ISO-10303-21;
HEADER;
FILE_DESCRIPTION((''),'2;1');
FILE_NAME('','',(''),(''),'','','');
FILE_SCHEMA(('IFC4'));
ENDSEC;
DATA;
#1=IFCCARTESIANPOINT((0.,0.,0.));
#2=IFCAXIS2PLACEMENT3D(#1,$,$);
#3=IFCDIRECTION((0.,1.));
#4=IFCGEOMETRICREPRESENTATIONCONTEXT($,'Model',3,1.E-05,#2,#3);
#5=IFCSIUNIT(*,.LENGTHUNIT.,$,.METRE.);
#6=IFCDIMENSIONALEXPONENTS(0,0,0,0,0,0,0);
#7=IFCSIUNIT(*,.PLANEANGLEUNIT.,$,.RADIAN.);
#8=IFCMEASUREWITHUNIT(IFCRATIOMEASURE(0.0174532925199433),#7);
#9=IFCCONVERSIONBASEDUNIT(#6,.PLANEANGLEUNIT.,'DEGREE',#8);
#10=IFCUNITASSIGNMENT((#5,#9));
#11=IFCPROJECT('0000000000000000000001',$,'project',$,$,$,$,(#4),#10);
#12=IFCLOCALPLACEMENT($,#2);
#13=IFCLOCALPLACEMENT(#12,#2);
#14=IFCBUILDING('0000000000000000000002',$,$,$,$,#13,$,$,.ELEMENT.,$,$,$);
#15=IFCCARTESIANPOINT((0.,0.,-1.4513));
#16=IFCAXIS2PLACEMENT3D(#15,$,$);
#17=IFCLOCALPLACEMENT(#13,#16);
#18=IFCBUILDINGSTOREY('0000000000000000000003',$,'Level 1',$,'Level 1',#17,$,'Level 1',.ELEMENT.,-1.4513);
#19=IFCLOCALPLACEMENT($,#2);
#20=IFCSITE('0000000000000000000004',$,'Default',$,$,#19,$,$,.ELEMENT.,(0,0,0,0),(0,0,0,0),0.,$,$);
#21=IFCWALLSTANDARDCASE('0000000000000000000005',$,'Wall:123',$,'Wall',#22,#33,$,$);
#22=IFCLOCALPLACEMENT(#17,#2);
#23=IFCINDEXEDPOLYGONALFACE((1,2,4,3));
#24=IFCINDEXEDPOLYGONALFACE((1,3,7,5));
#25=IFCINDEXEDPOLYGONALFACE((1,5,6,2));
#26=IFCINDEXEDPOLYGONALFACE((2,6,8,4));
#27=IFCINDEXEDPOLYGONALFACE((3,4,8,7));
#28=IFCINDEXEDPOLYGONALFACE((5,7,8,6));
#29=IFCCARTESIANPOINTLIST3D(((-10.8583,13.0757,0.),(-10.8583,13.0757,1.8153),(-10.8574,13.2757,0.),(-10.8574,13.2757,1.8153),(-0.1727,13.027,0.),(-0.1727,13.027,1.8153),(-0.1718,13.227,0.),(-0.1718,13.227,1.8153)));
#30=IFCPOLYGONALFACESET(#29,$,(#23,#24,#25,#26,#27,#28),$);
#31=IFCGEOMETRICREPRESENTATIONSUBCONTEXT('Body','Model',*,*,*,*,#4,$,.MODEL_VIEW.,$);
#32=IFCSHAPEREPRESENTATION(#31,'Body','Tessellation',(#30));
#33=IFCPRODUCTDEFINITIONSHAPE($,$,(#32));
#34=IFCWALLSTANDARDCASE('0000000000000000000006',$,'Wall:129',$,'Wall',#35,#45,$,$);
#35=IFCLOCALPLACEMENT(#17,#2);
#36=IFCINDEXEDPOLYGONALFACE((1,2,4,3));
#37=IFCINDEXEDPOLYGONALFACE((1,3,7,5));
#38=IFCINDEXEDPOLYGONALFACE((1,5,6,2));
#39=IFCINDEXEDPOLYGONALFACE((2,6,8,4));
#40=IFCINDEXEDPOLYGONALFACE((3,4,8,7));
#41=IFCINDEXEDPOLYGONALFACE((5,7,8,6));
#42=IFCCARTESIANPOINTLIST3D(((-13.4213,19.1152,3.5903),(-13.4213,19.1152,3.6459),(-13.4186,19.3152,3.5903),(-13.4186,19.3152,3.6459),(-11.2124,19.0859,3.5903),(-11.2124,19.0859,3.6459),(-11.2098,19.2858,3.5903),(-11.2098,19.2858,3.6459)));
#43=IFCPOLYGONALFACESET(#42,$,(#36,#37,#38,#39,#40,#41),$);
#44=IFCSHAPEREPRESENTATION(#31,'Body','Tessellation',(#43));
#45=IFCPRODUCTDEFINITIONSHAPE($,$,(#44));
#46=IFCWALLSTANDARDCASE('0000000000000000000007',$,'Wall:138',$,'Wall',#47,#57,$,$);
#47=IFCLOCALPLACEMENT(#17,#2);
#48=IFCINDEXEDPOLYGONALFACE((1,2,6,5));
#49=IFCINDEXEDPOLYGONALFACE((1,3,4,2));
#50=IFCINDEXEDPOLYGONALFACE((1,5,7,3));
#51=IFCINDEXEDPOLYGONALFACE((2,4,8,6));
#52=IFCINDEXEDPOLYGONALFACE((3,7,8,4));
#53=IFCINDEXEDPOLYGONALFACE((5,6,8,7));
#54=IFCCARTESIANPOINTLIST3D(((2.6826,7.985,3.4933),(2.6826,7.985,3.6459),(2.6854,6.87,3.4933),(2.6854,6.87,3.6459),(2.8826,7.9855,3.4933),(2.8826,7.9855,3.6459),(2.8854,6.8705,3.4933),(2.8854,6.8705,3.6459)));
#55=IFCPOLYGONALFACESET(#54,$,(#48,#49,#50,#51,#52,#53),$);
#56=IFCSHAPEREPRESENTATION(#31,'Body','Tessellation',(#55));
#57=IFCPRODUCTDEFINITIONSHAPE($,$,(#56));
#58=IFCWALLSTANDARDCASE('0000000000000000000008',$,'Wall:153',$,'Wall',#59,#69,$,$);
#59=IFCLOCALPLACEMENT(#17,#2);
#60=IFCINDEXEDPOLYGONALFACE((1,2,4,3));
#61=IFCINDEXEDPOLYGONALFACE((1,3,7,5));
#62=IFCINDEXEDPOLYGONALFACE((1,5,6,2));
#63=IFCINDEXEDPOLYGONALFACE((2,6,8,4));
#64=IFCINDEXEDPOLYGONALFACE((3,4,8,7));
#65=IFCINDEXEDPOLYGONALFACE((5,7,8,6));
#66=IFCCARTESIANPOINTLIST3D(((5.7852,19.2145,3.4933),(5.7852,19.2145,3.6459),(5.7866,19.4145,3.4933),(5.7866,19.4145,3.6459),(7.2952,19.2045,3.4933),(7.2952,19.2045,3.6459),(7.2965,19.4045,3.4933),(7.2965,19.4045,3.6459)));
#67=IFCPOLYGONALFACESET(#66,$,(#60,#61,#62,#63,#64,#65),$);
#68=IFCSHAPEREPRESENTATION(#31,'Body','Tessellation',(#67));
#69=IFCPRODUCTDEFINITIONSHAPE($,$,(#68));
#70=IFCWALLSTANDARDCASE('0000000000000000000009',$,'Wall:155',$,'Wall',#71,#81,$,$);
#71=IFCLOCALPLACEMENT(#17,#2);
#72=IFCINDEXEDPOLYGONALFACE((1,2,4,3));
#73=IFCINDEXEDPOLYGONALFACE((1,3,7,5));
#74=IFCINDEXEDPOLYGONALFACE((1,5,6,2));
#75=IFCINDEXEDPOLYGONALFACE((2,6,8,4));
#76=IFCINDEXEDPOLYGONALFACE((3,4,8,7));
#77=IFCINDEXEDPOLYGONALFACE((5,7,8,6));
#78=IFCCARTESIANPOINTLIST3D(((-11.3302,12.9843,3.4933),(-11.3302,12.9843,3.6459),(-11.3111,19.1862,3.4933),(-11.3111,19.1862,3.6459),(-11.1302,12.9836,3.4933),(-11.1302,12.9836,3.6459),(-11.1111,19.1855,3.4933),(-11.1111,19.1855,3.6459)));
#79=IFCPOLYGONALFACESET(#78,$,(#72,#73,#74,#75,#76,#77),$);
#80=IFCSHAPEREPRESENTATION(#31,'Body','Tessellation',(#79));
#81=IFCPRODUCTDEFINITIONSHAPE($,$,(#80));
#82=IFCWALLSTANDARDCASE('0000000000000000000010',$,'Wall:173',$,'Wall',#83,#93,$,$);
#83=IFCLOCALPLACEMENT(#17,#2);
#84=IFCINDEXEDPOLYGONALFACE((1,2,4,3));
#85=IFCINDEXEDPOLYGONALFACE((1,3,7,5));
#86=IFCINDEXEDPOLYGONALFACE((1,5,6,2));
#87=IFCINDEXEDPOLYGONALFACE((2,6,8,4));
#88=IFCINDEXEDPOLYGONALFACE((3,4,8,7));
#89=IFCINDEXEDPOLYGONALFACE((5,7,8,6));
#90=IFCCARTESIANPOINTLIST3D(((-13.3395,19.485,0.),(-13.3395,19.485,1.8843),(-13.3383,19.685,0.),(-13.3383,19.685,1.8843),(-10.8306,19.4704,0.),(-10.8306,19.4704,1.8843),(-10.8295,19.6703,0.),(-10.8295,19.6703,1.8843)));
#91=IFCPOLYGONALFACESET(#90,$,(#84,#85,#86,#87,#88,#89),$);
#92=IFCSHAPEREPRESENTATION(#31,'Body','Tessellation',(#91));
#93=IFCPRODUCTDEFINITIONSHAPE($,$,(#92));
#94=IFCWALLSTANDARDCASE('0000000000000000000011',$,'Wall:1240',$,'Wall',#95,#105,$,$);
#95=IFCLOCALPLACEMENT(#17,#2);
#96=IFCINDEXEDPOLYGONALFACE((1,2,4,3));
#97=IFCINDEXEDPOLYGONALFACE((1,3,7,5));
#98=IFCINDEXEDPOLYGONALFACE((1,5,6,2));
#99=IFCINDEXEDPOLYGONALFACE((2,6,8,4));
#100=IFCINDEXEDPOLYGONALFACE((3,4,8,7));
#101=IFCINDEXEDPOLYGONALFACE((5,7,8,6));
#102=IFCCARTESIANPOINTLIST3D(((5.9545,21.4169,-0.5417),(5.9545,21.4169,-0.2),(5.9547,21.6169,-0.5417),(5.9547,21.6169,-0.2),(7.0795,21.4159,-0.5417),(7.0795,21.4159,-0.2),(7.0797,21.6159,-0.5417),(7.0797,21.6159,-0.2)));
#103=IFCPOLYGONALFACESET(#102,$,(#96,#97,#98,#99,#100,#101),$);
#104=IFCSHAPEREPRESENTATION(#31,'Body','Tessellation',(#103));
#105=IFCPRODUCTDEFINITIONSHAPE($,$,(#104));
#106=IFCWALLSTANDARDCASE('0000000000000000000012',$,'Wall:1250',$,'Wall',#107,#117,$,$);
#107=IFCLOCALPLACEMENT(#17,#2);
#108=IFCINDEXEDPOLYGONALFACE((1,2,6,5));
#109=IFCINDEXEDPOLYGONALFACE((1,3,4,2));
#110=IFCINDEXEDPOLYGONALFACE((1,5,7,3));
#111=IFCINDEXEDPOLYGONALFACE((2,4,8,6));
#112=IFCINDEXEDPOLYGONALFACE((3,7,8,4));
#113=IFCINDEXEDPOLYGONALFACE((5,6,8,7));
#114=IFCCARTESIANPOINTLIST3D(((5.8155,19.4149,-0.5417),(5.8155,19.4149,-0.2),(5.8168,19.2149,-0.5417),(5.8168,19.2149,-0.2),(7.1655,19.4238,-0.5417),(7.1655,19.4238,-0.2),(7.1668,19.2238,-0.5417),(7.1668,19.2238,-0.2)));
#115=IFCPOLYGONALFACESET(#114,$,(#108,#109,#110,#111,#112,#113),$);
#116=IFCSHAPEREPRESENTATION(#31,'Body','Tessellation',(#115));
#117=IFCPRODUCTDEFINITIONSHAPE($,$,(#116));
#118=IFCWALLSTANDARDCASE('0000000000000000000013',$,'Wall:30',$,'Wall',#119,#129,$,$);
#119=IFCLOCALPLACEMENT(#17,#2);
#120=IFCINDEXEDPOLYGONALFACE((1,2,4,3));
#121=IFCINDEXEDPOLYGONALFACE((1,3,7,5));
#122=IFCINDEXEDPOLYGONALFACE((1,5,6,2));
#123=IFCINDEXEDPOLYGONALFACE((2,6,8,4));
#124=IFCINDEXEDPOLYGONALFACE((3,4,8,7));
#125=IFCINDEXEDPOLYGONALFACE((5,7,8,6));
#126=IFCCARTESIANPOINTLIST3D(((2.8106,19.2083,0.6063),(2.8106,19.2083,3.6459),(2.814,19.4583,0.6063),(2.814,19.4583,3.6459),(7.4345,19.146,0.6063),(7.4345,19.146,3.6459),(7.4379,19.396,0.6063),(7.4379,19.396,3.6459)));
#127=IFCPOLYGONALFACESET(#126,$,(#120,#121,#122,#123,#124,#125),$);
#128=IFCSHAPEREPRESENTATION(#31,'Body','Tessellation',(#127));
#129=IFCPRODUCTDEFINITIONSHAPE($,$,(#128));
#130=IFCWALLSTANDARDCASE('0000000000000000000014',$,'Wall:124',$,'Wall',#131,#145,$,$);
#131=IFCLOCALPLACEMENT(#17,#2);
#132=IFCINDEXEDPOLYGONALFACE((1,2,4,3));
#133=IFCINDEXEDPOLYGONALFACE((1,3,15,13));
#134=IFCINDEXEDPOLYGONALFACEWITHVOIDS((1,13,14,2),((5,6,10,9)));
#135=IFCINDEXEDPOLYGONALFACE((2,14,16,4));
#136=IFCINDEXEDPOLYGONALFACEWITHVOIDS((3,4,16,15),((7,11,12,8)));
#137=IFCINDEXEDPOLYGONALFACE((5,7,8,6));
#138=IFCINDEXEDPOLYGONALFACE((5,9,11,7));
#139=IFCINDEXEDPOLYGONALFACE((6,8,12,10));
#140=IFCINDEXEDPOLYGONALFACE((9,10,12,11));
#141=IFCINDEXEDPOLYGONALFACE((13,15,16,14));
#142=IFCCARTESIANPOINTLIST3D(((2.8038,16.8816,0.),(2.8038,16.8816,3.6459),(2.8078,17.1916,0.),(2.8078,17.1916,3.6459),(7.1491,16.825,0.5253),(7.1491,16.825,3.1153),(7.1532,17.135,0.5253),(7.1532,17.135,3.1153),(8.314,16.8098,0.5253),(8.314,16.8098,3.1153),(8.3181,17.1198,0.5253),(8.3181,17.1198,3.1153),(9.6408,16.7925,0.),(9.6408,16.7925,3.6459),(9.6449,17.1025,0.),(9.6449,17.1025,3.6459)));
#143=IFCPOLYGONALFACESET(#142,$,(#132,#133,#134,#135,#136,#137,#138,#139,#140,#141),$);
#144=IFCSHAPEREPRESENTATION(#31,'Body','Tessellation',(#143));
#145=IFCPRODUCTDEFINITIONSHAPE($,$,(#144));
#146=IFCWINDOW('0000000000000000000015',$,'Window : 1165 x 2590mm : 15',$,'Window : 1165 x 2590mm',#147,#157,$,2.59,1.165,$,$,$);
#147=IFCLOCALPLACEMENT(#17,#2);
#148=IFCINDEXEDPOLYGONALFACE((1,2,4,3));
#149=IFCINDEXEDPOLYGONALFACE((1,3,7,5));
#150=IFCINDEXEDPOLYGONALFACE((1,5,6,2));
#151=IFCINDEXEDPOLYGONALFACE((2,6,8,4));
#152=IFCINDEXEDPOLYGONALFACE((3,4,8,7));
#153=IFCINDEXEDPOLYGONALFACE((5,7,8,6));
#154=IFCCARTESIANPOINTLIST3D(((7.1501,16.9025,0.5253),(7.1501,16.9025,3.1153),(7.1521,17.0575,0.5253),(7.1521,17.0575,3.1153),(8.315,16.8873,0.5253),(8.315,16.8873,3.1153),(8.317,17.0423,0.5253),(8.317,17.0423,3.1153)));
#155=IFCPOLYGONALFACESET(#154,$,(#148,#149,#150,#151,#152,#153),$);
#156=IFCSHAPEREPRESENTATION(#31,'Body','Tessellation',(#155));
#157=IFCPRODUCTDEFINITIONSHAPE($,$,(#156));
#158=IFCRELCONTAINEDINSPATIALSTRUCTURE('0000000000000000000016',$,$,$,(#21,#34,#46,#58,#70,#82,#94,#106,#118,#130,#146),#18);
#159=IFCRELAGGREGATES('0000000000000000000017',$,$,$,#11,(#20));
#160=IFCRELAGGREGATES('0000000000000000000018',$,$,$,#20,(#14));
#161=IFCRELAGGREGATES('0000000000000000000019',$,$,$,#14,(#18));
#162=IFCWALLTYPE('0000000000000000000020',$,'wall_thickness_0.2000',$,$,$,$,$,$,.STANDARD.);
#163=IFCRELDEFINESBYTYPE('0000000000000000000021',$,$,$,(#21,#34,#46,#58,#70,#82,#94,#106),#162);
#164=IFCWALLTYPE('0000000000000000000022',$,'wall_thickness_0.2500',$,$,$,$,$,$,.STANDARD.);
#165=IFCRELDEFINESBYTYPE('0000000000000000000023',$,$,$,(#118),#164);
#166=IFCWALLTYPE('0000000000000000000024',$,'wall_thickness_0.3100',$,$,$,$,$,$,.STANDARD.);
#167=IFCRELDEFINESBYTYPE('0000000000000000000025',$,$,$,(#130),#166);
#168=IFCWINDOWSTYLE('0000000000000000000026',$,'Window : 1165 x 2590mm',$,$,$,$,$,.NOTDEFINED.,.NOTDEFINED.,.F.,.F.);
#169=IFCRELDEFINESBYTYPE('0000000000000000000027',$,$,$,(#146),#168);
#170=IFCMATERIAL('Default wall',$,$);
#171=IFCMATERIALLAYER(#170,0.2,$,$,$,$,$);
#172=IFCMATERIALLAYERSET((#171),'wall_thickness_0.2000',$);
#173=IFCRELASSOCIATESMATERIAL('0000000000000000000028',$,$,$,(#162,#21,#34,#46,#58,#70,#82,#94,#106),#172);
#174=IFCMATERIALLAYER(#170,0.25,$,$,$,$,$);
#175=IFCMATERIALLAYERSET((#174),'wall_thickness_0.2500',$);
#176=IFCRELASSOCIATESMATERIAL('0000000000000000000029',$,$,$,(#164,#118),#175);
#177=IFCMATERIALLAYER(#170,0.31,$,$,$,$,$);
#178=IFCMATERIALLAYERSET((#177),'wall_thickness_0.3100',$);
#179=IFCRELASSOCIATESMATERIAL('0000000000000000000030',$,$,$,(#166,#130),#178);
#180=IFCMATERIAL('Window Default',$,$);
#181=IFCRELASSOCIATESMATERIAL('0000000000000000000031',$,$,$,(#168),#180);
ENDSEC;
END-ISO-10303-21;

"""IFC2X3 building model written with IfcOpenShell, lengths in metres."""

from ifc_helpers import new_model, entity, si_unit, converted_unit, direction, frame, frame_2d, origin, origin_2d_with_axis, place, context, subcontext, project, spatial, polyline, rectangle, outline, extrude, source, transform, mapped, material, layer, layer_set, layer_usage, type_object, type_shapes, element, fill, save


model = new_model("IFC2X3")

# Units and contexts
model_context = context("Model", 3, precision=1e-05, world=origin(), true_north=direction((0.0, 1.0)))
body_context = subcontext(model_context, "Body", "Model", "MODEL_VIEW")
ifc_project = project(units=[si_unit("LENGTHUNIT", "METRE"), converted_unit("PLANEANGLEUNIT", "DEGREE", entity("IfcRatioMeasure", 0.0174532925199433), si_unit("PLANEANGLEUNIT", "RADIAN"), dimensions=[0, 0, 0, 0, 0, 0, 0])], contexts=[model_context])

# Site, building, storey
site_placement = place(None, origin())
site = spatial("IfcSite", under=ifc_project, at=site_placement, Name="Default", CompositionType="ELEMENT", RefLatitude=(0, 0, 0, 0), RefLongitude=(0, 0, 0, 0), RefElevation=0.0)
placement_1 = place(None, origin())
building_placement = place(placement_1, origin())
building = spatial("IfcBuilding", under=site, at=building_placement, CompositionType="ELEMENT")
storey_placement = place(building_placement, frame((0.0, 0.0, -1.4513)))
storey = spatial("IfcBuildingStorey", under=building, at=storey_placement, Name="Level 1", ObjectType="Level 1", LongName="Level 1", CompositionType="ELEMENT", Elevation=-1.4513)

# Shared definitions
ifc_material_1 = material(Name="Default wall")

# Shared definitions
ifc_material_2 = material(Name="Window Default")

# Walls
ifc_layer_1 = layer(ifc_material_1, 0.2)
ifc_layer_set_1 = layer_set([ifc_layer_1], Name="wall_thickness_0.2000")
ifc_layer_usage_1 = layer_usage(ifc_layer_set_1, "AXIS2", "POSITIVE", -0.1)
wall_type_1 = type_object("IfcWallType", Name="wall_thickness_0.2000", PredefinedType="STANDARD", material=ifc_layer_set_1)
wall_1_placement = place(storey_placement, frame((-10.8578, 13.1757, 0.0), z_axis=(0.0, 0.0, 1.0), x_axis=(0.99999, -0.004551, 0.0)))
element("IfcWallStandardCase", 1, at=wall_1_placement, inside=storey, type_object=wall_type_1, material=ifc_layer_usage_1, Name="Wall:123", ObjectType="Wall", context=body_context, shape_type="SweptSolid", body=[
    extrude(outline(polyline([(10.6857, -0.1), (10.6857, 0.1), (0.0, 0.1), (0.0, -0.1), (10.6857, -0.1)])), origin(), (0.0, 0.0, 1.0), 1.8153),
])
placement_2 = place(building_placement, frame((0.0, 0.0, 2.139)))
wall_2_placement = place(placement_2, frame((-13.4199, 19.2152, 0.0), z_axis=(0.0, 0.0, 1.0), x_axis=(0.999912, -0.013278, 0.0)))
element("IfcWallStandardCase", 2, at=wall_2_placement, inside=storey, type_object=wall_type_1, material=ifc_layer_usage_1, Name="Wall:129", ObjectType="Wall", context=body_context, shape_type="SweptSolid", body=[
    extrude(outline(polyline([(2.209, -0.1), (2.209, 0.1), (0.0, 0.1), (0.0, -0.1), (2.209, -0.1)])), origin(), (0.0, 0.0, 1.0), 0.0556),
])
placement_3 = place(building_placement, frame((0.0, 0.0, 2.042)))
wall_3_placement = place(placement_3, frame((2.7826, 7.9852, 0.0), z_axis=(0.0, 0.0, 1.0), x_axis=(0.002486, -0.999997, 0.0)))
element("IfcWallStandardCase", 3, at=wall_3_placement, inside=storey, type_object=wall_type_1, material=ifc_layer_usage_1, Name="Wall:138", ObjectType="Wall", context=body_context, shape_type="SweptSolid", body=[
    extrude(outline(polyline([(1.115, -0.1), (1.115, 0.1), (0.0, 0.1), (0.0, -0.1), (1.115, -0.1)])), origin(), (0.0, 0.0, 1.0), 0.1526),
])
placement_4 = place(building_placement, frame((0.0, 0.0, 2.042)))
wall_4_placement = place(placement_4, frame((5.7859, 19.3145, 0.0), z_axis=(0.0, 0.0, 1.0), x_axis=(0.999978, -0.006621, 0.0)))
element("IfcWallStandardCase", 4, at=wall_4_placement, inside=storey, type_object=wall_type_1, material=ifc_layer_usage_1, Name="Wall:153", ObjectType="Wall", context=body_context, shape_type="SweptSolid", body=[
    extrude(outline(polyline([(1.51, -0.1), (1.51, 0.1), (0.0, 0.1), (0.0, -0.1), (1.51, -0.1)])), origin(), (0.0, 0.0, 1.0), 0.1526),
])
placement_5 = place(building_placement, frame((0.0, 0.0, 2.042)))
wall_5_placement = place(placement_5, frame((-11.2111, 19.1859, 0.0), z_axis=(0.0, 0.0, 1.0), x_axis=(-0.003082, -0.999995, 0.0)))
element("IfcWallStandardCase", 5, at=wall_5_placement, inside=storey, type_object=wall_type_1, material=ifc_layer_usage_1, Name="Wall:155", ObjectType="Wall", context=body_context, shape_type="SweptSolid", body=[
    extrude(outline(polyline([(6.2019, -0.1), (6.2019, 0.1), (0.0, 0.1), (0.0, -0.1), (6.2019, -0.1)])), origin(), (0.0, 0.0, 1.0), 0.1526),
])
wall_6_placement = place(storey_placement, frame((-13.3389, 19.585, 0.0), z_axis=(0.0, 0.0, 1.0), x_axis=(0.999983, -0.005854, 0.0)))
element("IfcWallStandardCase", 6, at=wall_6_placement, inside=storey, type_object=wall_type_1, material=ifc_layer_usage_1, Name="Wall:173", ObjectType="Wall", context=body_context, shape_type="SweptSolid", body=[
    extrude(outline(polyline([(2.5089, -0.1), (2.5089, 0.1), (0.0, 0.1), (0.0, -0.1), (2.5089, -0.1)])), origin(), (0.0, 0.0, 1.0), 1.8843),
])
placement_6 = place(building_placement, frame((0.0, 0.0, -1.993)))
wall_7_placement = place(placement_6, frame((5.9546, 21.5169, 0.0), z_axis=(0.0, 0.0, 1.0), x_axis=(1.0, -0.000819, 0.0)))
element("IfcWallStandardCase", 7, at=wall_7_placement, inside=storey, type_object=wall_type_1, material=ifc_layer_usage_1, Name="Wall:1240", ObjectType="Wall", context=body_context, shape_type="SweptSolid", body=[
    extrude(outline(polyline([(1.125, -0.1), (1.125, 0.1), (0.0, 0.1), (0.0, -0.1), (1.125, -0.1)])), origin(), (0.0, 0.0, 1.0), 0.3417),
])
placement_7 = place(building_placement, frame((0.0, 0.0, -1.993)))
wall_8_placement = place(placement_7, frame((5.8161, 19.3149, 0.0), z_axis=(0.0, 0.0, 1.0), x_axis=(0.999978, 0.006563, 0.0)))
element("IfcWallStandardCase", 8, at=wall_8_placement, inside=storey, type_object=wall_type_1, material=ifc_layer_usage_1, Name="Wall:1250", ObjectType="Wall", context=body_context, shape_type="SweptSolid", body=[
    extrude(outline(polyline([(1.35, -0.1), (1.35, 0.1), (0.0, 0.1), (0.0, -0.1), (1.35, -0.1)])), origin(), (0.0, 0.0, 1.0), 0.3417),
])
ifc_layer_2 = layer(ifc_material_1, 0.25)
ifc_layer_set_2 = layer_set([ifc_layer_2], Name="wall_thickness_0.2500")
ifc_layer_usage_2 = layer_usage(ifc_layer_set_2, "AXIS2", "POSITIVE", -0.125)
wall_type_2 = type_object("IfcWallType", Name="wall_thickness_0.2500", PredefinedType="STANDARD", material=ifc_layer_set_2)
placement_8 = place(building_placement, frame((0.0, 0.0, -0.845)))
wall_9_placement = place(placement_8, frame((2.8123, 19.3333, 0.0), z_axis=(0.0, 0.0, 1.0), x_axis=(0.999909, -0.013466, 0.0)))
element("IfcWallStandardCase", 9, at=wall_9_placement, inside=storey, type_object=wall_type_2, material=ifc_layer_usage_2, Name="Wall:30", ObjectType="Wall", context=body_context, shape_type="SweptSolid", body=[
    extrude(outline(polyline([(4.6243, -0.125), (4.6243, 0.125), (0.0, 0.125), (0.0, -0.125), (4.6243, -0.125)])), origin(), (0.0, 0.0, 1.0), 3.0396),
])

# Wall, opening, window
ifc_layer_3 = layer(ifc_material_1, 0.31)
ifc_layer_set_3 = layer_set([ifc_layer_3], Name="wall_thickness_0.3100")
ifc_layer_usage_3 = layer_usage(ifc_layer_set_3, "AXIS2", "POSITIVE", -0.155)
wall_type_3 = type_object("IfcWallType", Name="wall_thickness_0.3100", PredefinedType="STANDARD", material=ifc_layer_set_3)
wall_10_placement = place(storey_placement, frame((2.8058, 17.0366, 0.0), z_axis=(0.0, 0.0, 1.0), x_axis=(0.999915, -0.013032, 0.0)))
wall_10 = element("IfcWallStandardCase", 10, at=wall_10_placement, inside=storey, type_object=wall_type_3, material=ifc_layer_usage_3, Name="Wall:124", ObjectType="Wall", context=body_context, shape_type="SweptSolid", body=[
    extrude(outline(polyline([(6.8376, -0.155), (6.8376, 0.155), (0.0, 0.155), (0.0, -0.155), (6.8376, -0.155)])), origin(), (0.0, 0.0, 1.0), 3.6459),
])
opening_1_placement = place(wall_10_placement, frame((4.3457, -0.155, 0.5253)))
opening_1 = element("IfcOpeningElement", 11, at=opening_1_placement, cuts=wall_10, ObjectType="Opening", context=body_context, shape_type="SweptSolid", body=[
    extrude(rectangle(XDim=1.165, YDim=2.59, at=frame_2d((1.295, 0.5825), x_axis=(0.0, 1.0))), frame((0.0, 0.0, 0.0), z_axis=(0.0, 1.0, 0.0), x_axis=(0.0, 0.0, 1.0)), (0.0, 0.0, 1.0), 0.31),
])
window_style_1 = type_object("IfcWindowStyle", Name="Window : 1165 x 2590mm", ConstructionType="NOTDEFINED", OperationType="NOTDEFINED", ParameterTakesPrecedence=False, Sizeable=False, material=ifc_material_2)
shared_shape_1 = source(origin(), body_context, "Body", "SweptSolid", [
    extrude(rectangle(XDim=0.155, YDim=1.165, at=origin_2d_with_axis()), frame((0.5825, 0.155, 0.0), z_axis=(0.0, 0.0, 1.0), x_axis=(0.0, 1.0, 0.0)), (0.0, 0.0, 1.0), 2.59),
])
type_shapes(window_style_1, [shared_shape_1])
window_1_placement = place(opening_1_placement, origin())
window_1 = element("IfcWindow", 12, at=window_1_placement, inside=storey, type_object=window_style_1, Name="Window : 1165 x 2590mm : 15", ObjectType="Window : 1165 x 2590mm", OverallHeight=2.59, OverallWidth=1.165, context=body_context, shape_type="MappedRepresentation", body=[
    mapped(shared_shape_1, transform((0.0, 0.0, 0.0), scale=1.0)),
])
fill(opening_1, window_1)

save(model, "model.ifc")
